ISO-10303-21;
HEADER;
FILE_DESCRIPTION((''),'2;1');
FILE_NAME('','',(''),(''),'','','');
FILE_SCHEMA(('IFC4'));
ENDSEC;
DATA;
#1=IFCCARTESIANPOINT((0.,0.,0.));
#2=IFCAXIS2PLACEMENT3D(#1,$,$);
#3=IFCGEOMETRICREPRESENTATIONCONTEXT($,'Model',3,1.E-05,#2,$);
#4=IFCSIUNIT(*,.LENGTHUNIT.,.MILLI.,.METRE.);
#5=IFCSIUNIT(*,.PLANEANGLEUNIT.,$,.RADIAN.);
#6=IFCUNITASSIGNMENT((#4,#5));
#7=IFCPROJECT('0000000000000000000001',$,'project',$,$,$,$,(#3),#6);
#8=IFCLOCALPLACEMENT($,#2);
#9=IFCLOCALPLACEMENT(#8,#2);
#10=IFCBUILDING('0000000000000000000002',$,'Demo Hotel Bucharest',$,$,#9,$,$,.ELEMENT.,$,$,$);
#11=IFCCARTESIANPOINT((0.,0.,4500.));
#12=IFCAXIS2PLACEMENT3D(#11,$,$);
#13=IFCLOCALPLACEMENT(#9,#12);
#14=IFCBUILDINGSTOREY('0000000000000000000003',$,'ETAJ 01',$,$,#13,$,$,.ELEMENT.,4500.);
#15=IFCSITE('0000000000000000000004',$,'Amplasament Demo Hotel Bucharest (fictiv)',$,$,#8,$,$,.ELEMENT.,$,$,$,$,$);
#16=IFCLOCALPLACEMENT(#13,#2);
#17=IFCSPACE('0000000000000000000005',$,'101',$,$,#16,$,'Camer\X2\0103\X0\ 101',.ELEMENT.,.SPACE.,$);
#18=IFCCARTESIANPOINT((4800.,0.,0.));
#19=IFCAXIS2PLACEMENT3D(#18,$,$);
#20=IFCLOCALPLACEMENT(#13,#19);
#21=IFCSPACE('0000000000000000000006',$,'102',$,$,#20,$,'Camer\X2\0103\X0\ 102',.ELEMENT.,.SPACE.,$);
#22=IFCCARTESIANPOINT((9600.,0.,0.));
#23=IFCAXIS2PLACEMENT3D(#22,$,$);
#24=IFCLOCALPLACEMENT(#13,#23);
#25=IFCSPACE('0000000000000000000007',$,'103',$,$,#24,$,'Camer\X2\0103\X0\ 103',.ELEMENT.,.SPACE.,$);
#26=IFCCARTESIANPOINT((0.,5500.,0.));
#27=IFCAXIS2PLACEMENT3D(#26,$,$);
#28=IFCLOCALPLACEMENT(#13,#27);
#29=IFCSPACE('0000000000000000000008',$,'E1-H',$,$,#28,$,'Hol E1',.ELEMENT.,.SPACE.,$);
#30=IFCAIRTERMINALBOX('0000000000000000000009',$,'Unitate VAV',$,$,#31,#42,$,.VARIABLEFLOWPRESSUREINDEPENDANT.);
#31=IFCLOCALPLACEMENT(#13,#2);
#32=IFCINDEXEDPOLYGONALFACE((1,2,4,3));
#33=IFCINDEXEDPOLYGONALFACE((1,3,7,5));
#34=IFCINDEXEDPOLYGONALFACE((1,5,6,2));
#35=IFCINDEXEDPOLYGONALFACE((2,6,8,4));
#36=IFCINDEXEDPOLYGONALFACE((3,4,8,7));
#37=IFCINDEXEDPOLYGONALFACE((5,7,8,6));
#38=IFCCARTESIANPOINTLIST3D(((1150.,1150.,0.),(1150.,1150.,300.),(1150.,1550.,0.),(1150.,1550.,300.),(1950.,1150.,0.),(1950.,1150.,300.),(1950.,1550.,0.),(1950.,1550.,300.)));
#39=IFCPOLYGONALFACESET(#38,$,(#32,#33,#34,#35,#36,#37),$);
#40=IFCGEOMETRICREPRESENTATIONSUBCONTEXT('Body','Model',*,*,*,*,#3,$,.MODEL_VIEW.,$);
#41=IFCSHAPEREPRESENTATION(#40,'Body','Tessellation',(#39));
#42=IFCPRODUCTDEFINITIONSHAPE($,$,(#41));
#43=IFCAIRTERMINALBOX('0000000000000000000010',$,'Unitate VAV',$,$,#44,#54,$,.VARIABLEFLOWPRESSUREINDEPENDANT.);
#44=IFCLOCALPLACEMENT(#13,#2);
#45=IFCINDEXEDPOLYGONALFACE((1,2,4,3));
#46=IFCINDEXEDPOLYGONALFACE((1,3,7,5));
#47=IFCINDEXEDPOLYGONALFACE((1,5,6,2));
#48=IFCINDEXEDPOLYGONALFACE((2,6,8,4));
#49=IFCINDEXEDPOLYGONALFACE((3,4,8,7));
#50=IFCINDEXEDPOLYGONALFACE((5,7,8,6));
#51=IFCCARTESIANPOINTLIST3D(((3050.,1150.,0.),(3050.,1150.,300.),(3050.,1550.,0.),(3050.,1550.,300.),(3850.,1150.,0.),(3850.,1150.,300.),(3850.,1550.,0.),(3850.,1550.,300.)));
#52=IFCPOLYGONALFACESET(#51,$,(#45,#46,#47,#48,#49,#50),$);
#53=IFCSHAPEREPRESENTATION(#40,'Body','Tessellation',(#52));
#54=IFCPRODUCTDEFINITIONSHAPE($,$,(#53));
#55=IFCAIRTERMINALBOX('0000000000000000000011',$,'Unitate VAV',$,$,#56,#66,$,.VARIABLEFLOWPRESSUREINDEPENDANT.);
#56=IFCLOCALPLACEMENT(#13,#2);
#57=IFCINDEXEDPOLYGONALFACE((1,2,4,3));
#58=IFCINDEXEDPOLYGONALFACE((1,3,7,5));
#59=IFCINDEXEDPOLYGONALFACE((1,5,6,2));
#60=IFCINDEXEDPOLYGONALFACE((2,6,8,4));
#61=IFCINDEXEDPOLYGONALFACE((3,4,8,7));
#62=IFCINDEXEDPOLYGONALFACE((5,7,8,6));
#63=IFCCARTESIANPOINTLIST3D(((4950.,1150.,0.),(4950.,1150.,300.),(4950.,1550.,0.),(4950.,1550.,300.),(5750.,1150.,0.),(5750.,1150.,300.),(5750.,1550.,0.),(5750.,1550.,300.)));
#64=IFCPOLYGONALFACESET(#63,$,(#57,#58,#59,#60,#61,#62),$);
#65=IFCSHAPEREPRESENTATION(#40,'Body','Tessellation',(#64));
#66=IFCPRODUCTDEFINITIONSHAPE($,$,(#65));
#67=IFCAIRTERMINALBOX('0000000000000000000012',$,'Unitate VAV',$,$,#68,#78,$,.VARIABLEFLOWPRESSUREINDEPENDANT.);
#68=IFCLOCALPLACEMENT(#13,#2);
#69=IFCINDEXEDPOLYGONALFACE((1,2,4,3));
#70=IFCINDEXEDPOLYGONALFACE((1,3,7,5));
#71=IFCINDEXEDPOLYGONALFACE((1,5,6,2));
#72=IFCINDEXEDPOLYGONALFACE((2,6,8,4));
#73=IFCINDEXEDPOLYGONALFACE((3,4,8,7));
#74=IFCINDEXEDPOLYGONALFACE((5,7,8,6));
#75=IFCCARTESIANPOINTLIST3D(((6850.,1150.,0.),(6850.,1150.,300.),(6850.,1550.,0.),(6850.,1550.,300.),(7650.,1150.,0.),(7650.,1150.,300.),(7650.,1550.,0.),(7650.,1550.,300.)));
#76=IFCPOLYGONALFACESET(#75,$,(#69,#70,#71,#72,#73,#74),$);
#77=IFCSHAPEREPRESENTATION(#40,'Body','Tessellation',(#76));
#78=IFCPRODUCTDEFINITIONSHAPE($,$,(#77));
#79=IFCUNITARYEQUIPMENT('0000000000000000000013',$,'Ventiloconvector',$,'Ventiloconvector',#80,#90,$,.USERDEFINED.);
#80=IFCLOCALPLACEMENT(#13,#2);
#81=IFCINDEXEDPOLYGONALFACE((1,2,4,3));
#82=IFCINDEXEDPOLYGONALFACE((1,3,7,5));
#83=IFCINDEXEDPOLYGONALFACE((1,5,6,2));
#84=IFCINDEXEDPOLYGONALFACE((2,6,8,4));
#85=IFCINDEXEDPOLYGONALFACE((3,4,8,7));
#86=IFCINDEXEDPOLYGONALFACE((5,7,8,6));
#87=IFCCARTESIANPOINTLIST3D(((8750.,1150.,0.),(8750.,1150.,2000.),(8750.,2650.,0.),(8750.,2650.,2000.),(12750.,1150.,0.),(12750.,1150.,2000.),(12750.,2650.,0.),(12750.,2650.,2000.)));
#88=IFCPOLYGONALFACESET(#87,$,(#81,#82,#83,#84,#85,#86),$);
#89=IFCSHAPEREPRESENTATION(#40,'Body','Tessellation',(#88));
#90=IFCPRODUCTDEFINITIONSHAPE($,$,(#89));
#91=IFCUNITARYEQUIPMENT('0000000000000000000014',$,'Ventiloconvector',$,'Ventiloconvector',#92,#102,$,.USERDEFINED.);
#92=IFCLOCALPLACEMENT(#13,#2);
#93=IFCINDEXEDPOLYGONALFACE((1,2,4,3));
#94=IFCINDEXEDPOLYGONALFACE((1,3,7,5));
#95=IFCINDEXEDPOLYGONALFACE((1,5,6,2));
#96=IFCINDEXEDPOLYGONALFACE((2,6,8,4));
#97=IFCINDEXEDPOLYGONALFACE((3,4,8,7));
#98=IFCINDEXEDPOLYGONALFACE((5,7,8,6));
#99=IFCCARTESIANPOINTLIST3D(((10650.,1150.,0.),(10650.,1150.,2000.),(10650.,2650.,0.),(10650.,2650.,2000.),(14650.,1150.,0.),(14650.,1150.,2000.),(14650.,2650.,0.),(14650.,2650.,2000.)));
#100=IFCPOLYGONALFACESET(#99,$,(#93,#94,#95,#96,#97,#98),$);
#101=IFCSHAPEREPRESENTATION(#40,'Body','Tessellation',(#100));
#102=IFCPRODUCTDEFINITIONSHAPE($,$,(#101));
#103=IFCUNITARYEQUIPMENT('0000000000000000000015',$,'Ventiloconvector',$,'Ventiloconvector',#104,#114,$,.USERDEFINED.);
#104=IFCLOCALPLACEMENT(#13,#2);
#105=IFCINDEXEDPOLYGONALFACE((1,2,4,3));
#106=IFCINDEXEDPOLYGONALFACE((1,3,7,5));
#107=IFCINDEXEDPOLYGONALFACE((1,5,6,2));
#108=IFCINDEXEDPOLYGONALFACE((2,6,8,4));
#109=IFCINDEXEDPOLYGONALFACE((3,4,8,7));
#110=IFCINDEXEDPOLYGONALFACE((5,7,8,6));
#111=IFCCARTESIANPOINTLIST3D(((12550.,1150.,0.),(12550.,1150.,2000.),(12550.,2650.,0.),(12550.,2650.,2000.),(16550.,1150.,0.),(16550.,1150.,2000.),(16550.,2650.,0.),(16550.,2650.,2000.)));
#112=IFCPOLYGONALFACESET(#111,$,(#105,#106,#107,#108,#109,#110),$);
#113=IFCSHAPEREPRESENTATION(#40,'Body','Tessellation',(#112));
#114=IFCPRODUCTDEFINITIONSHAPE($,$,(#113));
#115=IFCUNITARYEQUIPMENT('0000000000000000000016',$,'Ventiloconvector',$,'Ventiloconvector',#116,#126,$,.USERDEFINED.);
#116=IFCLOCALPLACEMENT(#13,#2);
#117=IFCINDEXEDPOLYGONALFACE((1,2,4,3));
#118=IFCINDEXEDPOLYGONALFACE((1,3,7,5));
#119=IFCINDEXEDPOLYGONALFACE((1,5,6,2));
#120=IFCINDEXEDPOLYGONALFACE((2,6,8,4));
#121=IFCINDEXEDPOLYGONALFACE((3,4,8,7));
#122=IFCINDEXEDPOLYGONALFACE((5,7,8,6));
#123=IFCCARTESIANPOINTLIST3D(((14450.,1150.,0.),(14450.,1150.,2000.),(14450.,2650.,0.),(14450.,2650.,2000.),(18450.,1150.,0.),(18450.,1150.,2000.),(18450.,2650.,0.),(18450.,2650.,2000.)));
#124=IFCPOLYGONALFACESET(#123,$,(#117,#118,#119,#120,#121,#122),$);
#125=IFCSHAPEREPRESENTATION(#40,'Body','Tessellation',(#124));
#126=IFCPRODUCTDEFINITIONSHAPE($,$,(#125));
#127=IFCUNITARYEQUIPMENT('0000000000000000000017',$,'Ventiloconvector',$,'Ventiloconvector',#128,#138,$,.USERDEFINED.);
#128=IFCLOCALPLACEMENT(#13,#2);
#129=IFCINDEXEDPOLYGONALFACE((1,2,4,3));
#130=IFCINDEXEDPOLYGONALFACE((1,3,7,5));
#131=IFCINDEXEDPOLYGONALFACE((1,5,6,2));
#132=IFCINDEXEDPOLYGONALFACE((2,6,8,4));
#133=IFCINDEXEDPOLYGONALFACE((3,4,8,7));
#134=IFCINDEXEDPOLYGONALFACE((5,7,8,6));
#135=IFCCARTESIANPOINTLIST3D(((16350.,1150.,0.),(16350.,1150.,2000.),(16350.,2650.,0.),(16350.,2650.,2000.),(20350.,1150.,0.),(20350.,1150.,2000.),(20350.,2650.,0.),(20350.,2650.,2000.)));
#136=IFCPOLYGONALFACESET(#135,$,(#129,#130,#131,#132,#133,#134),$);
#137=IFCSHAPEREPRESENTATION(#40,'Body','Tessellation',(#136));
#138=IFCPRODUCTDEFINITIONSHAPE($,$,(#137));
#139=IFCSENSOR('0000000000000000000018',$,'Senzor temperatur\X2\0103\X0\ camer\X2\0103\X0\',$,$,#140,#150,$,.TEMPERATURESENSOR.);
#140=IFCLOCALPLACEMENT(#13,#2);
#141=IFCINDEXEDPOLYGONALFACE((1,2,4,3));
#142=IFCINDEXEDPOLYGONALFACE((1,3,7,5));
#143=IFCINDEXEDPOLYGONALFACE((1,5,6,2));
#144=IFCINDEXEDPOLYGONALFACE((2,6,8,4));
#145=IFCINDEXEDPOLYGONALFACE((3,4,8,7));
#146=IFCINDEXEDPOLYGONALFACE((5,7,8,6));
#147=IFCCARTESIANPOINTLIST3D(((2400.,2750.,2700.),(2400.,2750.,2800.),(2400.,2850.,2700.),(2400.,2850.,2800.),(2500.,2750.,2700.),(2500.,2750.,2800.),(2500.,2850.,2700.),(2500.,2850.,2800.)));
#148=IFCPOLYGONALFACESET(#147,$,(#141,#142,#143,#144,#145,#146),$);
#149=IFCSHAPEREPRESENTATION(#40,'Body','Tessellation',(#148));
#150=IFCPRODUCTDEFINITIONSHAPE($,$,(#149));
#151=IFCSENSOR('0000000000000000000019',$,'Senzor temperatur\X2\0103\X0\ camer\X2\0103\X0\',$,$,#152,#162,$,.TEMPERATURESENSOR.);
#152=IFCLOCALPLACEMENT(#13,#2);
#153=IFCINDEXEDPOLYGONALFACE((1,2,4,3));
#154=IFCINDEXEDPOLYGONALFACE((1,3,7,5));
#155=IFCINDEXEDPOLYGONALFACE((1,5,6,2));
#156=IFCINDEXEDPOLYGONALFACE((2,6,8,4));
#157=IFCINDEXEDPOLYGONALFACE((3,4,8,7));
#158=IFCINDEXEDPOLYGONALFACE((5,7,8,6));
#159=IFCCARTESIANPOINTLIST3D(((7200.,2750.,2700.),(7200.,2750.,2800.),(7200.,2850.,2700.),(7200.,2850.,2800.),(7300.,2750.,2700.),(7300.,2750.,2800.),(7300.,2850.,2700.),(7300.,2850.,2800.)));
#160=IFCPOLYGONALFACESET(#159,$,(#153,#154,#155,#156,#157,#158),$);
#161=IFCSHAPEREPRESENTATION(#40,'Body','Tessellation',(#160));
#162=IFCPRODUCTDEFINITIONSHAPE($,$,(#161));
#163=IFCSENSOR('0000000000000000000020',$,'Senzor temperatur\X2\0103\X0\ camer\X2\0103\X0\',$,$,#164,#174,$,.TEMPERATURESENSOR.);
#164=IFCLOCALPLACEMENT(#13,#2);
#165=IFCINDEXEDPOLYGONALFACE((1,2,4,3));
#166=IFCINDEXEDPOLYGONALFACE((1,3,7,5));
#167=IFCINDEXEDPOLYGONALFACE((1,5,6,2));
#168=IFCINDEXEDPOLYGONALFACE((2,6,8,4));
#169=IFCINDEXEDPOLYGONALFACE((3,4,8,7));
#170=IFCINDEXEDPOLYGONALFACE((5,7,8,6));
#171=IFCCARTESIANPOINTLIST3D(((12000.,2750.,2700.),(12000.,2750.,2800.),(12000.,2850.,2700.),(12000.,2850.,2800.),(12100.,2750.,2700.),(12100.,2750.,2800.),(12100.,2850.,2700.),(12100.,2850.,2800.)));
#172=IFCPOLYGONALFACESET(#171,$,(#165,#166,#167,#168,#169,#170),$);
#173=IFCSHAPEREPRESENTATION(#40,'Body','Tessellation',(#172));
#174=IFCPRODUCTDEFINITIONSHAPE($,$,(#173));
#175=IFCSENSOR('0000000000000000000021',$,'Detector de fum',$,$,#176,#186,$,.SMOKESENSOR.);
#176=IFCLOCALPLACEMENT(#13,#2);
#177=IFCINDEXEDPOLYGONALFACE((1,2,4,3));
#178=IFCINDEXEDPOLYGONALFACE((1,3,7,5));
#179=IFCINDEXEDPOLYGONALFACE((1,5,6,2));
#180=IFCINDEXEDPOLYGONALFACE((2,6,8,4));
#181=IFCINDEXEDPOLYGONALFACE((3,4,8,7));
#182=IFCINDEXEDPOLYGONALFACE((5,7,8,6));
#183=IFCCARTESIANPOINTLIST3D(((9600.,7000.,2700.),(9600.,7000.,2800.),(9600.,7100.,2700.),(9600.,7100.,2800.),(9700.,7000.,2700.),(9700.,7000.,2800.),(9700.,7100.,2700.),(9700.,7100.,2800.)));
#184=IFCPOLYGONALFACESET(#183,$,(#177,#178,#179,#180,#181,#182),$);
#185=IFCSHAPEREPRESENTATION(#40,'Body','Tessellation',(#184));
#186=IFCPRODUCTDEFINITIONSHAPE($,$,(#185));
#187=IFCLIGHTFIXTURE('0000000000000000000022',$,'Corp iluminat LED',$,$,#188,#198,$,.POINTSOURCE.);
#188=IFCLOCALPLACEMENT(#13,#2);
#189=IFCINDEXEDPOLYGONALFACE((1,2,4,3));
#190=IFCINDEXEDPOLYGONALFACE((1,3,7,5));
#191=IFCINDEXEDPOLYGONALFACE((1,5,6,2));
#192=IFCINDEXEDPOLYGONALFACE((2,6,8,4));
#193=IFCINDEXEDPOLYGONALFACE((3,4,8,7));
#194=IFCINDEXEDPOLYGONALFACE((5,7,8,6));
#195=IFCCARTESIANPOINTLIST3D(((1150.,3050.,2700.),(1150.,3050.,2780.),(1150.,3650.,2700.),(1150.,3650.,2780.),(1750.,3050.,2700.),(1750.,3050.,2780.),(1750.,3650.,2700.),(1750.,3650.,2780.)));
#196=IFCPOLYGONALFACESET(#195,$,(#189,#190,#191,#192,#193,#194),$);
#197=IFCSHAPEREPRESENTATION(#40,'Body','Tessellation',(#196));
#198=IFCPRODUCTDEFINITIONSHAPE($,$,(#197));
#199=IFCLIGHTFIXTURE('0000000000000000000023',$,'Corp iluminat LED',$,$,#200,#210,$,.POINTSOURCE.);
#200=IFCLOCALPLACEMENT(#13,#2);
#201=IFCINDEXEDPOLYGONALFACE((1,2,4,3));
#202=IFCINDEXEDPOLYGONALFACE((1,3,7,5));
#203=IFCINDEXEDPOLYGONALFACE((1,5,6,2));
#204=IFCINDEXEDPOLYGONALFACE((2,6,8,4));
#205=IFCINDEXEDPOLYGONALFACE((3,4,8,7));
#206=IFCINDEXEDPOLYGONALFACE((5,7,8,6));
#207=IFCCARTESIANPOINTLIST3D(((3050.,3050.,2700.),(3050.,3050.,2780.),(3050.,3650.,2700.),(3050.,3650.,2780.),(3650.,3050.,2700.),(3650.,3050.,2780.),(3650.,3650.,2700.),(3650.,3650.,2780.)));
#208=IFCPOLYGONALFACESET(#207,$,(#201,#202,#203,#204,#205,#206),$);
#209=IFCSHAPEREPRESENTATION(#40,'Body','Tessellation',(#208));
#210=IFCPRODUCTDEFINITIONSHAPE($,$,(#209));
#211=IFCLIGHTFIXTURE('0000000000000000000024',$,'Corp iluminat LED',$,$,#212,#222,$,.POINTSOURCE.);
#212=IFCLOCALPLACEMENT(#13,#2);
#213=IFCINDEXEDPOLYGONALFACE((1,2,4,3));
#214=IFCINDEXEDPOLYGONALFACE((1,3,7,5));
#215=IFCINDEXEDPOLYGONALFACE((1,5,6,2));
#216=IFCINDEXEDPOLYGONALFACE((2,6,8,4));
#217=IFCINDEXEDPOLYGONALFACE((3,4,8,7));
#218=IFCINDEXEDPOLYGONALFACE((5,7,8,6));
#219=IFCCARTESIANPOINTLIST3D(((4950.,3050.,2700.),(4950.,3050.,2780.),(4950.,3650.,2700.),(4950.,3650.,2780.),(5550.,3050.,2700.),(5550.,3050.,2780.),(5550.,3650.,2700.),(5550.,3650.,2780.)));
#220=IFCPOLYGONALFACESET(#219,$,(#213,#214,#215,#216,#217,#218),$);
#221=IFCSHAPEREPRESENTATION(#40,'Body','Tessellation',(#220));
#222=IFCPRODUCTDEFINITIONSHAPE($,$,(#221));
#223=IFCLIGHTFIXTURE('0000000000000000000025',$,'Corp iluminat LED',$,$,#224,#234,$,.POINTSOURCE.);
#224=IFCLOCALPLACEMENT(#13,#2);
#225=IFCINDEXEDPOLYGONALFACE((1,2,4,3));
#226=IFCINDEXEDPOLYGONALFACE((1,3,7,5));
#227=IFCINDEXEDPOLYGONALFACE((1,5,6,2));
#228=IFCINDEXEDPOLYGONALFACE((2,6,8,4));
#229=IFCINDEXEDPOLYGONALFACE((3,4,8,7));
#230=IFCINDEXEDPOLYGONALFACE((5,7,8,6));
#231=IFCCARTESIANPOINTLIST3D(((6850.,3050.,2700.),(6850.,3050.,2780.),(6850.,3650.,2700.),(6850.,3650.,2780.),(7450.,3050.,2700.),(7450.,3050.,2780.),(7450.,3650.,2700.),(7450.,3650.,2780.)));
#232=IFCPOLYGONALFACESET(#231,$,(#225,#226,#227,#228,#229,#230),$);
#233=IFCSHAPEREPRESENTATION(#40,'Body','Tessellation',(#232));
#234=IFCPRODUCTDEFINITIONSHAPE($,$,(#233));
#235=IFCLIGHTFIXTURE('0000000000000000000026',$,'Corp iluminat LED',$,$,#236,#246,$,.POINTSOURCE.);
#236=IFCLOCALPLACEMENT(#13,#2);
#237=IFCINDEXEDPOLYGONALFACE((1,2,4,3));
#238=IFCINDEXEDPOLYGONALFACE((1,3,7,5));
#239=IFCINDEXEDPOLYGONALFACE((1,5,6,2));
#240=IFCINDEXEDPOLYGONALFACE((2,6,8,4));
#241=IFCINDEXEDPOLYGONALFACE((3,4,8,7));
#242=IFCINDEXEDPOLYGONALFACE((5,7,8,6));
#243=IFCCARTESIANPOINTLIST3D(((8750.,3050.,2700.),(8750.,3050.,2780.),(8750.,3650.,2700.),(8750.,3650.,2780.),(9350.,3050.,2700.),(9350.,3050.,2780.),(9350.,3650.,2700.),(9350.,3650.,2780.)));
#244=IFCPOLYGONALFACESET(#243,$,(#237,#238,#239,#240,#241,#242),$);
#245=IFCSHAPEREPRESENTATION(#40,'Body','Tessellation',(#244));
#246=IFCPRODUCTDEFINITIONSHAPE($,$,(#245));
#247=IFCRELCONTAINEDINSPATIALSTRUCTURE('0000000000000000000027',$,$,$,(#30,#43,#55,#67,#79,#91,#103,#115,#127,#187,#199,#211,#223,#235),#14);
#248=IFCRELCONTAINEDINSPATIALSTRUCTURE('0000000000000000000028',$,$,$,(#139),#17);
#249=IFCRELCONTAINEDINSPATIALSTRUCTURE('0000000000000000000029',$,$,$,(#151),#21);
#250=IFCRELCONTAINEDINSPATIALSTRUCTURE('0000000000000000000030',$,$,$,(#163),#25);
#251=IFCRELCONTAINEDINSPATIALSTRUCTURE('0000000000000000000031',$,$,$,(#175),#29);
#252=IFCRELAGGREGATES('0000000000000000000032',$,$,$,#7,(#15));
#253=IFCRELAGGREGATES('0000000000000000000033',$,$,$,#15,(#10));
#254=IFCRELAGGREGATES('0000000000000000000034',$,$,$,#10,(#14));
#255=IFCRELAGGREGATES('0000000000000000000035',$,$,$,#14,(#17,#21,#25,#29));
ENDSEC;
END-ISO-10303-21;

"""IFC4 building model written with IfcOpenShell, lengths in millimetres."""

from ifc_helpers import new_model, si_unit, frame, frame_2d, origin, place, context, subcontext, project, spatial, rectangle, extrude, element, save


model = new_model("IFC4")

# Units and contexts
model_context = context("Model", 3, precision=1e-05, world=origin())
body_context = subcontext(model_context, "Body", "Model", "MODEL_VIEW")
ifc_project = project(units=[si_unit("LENGTHUNIT", "METRE", prefix="MILLI"), si_unit("PLANEANGLEUNIT", "RADIAN")], contexts=[model_context])

# Site, building, storey
site_placement = place(None, origin())
site = spatial("IfcSite", under=ifc_project, at=site_placement, Name="Amplasament Demo Hotel Bucharest (fictiv)", CompositionType="ELEMENT")
building_placement = place(site_placement, origin())
building = spatial("IfcBuilding", under=site, at=building_placement, Name="Demo Hotel Bucharest", CompositionType="ELEMENT")
storey_placement = place(building_placement, frame((0.0, 0.0, 4500.0)))
storey = spatial("IfcBuildingStorey", under=building, at=storey_placement, Name="ETAJ 01", CompositionType="ELEMENT", Elevation=4500.0)

# Air terminal boxes
for number, where, name in (
    (1, (1150.0, 1150.0, 0.0), "Unitate VAV"),
    (2, (3050.0, 1150.0, 0.0), "Unitate VAV"),
    (3, (4950.0, 1150.0, 0.0), "Unitate VAV"),
    (4, (6850.0, 1150.0, 0.0), "Unitate VAV"),
):
    element("IfcAirTerminalBox", number, at=place(storey_placement, frame(where)), inside=storey, Name=name, PredefinedType="VARIABLEFLOWPRESSUREINDEPENDANT", context=body_context, shape_type="SweptSolid", body=[
        extrude(rectangle(XDim=800.0, YDim=400.0, at=frame_2d((400.0, 200.0))), origin(), (0.0, 0.0, 1.0), 300.0),
    ])

# Unitary equipment
for number, where, name in (
    (5, (8750.0, 1150.0, 0.0), "Ventiloconvector"),
    (6, (10650.0, 1150.0, 0.0), "Ventiloconvector"),
    (7, (12550.0, 1150.0, 0.0), "Ventiloconvector"),
    (8, (14450.0, 1150.0, 0.0), "Ventiloconvector"),
    (9, (16350.0, 1150.0, 0.0), "Ventiloconvector"),
):
    element("IfcUnitaryEquipment", number, at=place(storey_placement, frame(where)), inside=storey, Name=name, ObjectType="Ventiloconvector", PredefinedType="USERDEFINED", context=body_context, shape_type="SweptSolid", body=[
        extrude(rectangle(XDim=4000.0, YDim=1500.0, at=frame_2d((2000.0, 750.0))), origin(), (0.0, 0.0, 1.0), 2000.0),
    ])

# Shared definitions
space_1_placement = place(storey_placement, origin())
space_1 = spatial("IfcSpace", under=storey, at=space_1_placement, Name="101", LongName="Cameră 101", CompositionType="ELEMENT", PredefinedType="SPACE")

# Sensor
sensor_1_placement = place(storey_placement, frame((2400.0, 2750.0, 2700.0)))
element("IfcSensor", 10, at=sensor_1_placement, inside=space_1, Name="Senzor temperatură cameră", PredefinedType="TEMPERATURESENSOR", context=body_context, shape_type="SweptSolid", body=[
    extrude(rectangle(XDim=100.0, YDim=100.0, at=frame_2d((50.0, 50.0))), origin(), (0.0, 0.0, 1.0), 100.0),
])

# Shared definitions
space_2_placement = place(storey_placement, frame((4800.0, 0.0, 0.0)))
space_2 = spatial("IfcSpace", under=storey, at=space_2_placement, Name="102", LongName="Cameră 102", CompositionType="ELEMENT", PredefinedType="SPACE")

# Sensor
sensor_2_placement = place(storey_placement, frame((7200.0, 2750.0, 2700.0)))
element("IfcSensor", 11, at=sensor_2_placement, inside=space_2, Name="Senzor temperatură cameră", PredefinedType="TEMPERATURESENSOR", context=body_context, shape_type="SweptSolid", body=[
    extrude(rectangle(XDim=100.0, YDim=100.0, at=frame_2d((50.0, 50.0))), origin(), (0.0, 0.0, 1.0), 100.0),
])

# Shared definitions
space_3_placement = place(storey_placement, frame((9600.0, 0.0, 0.0)))
space_3 = spatial("IfcSpace", under=storey, at=space_3_placement, Name="103", LongName="Cameră 103", CompositionType="ELEMENT", PredefinedType="SPACE")

# Sensor
sensor_3_placement = place(storey_placement, frame((12000.0, 2750.0, 2700.0)))
element("IfcSensor", 12, at=sensor_3_placement, inside=space_3, Name="Senzor temperatură cameră", PredefinedType="TEMPERATURESENSOR", context=body_context, shape_type="SweptSolid", body=[
    extrude(rectangle(XDim=100.0, YDim=100.0, at=frame_2d((50.0, 50.0))), origin(), (0.0, 0.0, 1.0), 100.0),
])

# Shared definitions
space_4_placement = place(storey_placement, frame((0.0, 5500.0, 0.0)))
space_4 = spatial("IfcSpace", under=storey, at=space_4_placement, Name="E1-H", LongName="Hol E1", CompositionType="ELEMENT", PredefinedType="SPACE")

# Sensor
sensor_4_placement = place(storey_placement, frame((9600.0, 7000.0, 2700.0)))
element("IfcSensor", 13, at=sensor_4_placement, inside=space_4, Name="Detector de fum", PredefinedType="SMOKESENSOR", context=body_context, shape_type="SweptSolid", body=[
    extrude(rectangle(XDim=100.0, YDim=100.0, at=frame_2d((50.0, 50.0))), origin(), (0.0, 0.0, 1.0), 100.0),
])

# Light fixtures
for number, where, name in (
    (14, (1150.0, 3050.0, 2700.0), "Corp iluminat LED"),
    (15, (3050.0, 3050.0, 2700.0), "Corp iluminat LED"),
    (16, (4950.0, 3050.0, 2700.0), "Corp iluminat LED"),
    (17, (6850.0, 3050.0, 2700.0), "Corp iluminat LED"),
    (18, (8750.0, 3050.0, 2700.0), "Corp iluminat LED"),
):
    element("IfcLightFixture", number, at=place(storey_placement, frame(where)), inside=storey, Name=name, PredefinedType="POINTSOURCE", context=body_context, shape_type="SweptSolid", body=[
        extrude(rectangle(XDim=600.0, YDim=600.0, at=frame_2d((300.0, 300.0))), origin(), (0.0, 0.0, 1.0), 80.0),
    ])

save(model, "model.ifc")
